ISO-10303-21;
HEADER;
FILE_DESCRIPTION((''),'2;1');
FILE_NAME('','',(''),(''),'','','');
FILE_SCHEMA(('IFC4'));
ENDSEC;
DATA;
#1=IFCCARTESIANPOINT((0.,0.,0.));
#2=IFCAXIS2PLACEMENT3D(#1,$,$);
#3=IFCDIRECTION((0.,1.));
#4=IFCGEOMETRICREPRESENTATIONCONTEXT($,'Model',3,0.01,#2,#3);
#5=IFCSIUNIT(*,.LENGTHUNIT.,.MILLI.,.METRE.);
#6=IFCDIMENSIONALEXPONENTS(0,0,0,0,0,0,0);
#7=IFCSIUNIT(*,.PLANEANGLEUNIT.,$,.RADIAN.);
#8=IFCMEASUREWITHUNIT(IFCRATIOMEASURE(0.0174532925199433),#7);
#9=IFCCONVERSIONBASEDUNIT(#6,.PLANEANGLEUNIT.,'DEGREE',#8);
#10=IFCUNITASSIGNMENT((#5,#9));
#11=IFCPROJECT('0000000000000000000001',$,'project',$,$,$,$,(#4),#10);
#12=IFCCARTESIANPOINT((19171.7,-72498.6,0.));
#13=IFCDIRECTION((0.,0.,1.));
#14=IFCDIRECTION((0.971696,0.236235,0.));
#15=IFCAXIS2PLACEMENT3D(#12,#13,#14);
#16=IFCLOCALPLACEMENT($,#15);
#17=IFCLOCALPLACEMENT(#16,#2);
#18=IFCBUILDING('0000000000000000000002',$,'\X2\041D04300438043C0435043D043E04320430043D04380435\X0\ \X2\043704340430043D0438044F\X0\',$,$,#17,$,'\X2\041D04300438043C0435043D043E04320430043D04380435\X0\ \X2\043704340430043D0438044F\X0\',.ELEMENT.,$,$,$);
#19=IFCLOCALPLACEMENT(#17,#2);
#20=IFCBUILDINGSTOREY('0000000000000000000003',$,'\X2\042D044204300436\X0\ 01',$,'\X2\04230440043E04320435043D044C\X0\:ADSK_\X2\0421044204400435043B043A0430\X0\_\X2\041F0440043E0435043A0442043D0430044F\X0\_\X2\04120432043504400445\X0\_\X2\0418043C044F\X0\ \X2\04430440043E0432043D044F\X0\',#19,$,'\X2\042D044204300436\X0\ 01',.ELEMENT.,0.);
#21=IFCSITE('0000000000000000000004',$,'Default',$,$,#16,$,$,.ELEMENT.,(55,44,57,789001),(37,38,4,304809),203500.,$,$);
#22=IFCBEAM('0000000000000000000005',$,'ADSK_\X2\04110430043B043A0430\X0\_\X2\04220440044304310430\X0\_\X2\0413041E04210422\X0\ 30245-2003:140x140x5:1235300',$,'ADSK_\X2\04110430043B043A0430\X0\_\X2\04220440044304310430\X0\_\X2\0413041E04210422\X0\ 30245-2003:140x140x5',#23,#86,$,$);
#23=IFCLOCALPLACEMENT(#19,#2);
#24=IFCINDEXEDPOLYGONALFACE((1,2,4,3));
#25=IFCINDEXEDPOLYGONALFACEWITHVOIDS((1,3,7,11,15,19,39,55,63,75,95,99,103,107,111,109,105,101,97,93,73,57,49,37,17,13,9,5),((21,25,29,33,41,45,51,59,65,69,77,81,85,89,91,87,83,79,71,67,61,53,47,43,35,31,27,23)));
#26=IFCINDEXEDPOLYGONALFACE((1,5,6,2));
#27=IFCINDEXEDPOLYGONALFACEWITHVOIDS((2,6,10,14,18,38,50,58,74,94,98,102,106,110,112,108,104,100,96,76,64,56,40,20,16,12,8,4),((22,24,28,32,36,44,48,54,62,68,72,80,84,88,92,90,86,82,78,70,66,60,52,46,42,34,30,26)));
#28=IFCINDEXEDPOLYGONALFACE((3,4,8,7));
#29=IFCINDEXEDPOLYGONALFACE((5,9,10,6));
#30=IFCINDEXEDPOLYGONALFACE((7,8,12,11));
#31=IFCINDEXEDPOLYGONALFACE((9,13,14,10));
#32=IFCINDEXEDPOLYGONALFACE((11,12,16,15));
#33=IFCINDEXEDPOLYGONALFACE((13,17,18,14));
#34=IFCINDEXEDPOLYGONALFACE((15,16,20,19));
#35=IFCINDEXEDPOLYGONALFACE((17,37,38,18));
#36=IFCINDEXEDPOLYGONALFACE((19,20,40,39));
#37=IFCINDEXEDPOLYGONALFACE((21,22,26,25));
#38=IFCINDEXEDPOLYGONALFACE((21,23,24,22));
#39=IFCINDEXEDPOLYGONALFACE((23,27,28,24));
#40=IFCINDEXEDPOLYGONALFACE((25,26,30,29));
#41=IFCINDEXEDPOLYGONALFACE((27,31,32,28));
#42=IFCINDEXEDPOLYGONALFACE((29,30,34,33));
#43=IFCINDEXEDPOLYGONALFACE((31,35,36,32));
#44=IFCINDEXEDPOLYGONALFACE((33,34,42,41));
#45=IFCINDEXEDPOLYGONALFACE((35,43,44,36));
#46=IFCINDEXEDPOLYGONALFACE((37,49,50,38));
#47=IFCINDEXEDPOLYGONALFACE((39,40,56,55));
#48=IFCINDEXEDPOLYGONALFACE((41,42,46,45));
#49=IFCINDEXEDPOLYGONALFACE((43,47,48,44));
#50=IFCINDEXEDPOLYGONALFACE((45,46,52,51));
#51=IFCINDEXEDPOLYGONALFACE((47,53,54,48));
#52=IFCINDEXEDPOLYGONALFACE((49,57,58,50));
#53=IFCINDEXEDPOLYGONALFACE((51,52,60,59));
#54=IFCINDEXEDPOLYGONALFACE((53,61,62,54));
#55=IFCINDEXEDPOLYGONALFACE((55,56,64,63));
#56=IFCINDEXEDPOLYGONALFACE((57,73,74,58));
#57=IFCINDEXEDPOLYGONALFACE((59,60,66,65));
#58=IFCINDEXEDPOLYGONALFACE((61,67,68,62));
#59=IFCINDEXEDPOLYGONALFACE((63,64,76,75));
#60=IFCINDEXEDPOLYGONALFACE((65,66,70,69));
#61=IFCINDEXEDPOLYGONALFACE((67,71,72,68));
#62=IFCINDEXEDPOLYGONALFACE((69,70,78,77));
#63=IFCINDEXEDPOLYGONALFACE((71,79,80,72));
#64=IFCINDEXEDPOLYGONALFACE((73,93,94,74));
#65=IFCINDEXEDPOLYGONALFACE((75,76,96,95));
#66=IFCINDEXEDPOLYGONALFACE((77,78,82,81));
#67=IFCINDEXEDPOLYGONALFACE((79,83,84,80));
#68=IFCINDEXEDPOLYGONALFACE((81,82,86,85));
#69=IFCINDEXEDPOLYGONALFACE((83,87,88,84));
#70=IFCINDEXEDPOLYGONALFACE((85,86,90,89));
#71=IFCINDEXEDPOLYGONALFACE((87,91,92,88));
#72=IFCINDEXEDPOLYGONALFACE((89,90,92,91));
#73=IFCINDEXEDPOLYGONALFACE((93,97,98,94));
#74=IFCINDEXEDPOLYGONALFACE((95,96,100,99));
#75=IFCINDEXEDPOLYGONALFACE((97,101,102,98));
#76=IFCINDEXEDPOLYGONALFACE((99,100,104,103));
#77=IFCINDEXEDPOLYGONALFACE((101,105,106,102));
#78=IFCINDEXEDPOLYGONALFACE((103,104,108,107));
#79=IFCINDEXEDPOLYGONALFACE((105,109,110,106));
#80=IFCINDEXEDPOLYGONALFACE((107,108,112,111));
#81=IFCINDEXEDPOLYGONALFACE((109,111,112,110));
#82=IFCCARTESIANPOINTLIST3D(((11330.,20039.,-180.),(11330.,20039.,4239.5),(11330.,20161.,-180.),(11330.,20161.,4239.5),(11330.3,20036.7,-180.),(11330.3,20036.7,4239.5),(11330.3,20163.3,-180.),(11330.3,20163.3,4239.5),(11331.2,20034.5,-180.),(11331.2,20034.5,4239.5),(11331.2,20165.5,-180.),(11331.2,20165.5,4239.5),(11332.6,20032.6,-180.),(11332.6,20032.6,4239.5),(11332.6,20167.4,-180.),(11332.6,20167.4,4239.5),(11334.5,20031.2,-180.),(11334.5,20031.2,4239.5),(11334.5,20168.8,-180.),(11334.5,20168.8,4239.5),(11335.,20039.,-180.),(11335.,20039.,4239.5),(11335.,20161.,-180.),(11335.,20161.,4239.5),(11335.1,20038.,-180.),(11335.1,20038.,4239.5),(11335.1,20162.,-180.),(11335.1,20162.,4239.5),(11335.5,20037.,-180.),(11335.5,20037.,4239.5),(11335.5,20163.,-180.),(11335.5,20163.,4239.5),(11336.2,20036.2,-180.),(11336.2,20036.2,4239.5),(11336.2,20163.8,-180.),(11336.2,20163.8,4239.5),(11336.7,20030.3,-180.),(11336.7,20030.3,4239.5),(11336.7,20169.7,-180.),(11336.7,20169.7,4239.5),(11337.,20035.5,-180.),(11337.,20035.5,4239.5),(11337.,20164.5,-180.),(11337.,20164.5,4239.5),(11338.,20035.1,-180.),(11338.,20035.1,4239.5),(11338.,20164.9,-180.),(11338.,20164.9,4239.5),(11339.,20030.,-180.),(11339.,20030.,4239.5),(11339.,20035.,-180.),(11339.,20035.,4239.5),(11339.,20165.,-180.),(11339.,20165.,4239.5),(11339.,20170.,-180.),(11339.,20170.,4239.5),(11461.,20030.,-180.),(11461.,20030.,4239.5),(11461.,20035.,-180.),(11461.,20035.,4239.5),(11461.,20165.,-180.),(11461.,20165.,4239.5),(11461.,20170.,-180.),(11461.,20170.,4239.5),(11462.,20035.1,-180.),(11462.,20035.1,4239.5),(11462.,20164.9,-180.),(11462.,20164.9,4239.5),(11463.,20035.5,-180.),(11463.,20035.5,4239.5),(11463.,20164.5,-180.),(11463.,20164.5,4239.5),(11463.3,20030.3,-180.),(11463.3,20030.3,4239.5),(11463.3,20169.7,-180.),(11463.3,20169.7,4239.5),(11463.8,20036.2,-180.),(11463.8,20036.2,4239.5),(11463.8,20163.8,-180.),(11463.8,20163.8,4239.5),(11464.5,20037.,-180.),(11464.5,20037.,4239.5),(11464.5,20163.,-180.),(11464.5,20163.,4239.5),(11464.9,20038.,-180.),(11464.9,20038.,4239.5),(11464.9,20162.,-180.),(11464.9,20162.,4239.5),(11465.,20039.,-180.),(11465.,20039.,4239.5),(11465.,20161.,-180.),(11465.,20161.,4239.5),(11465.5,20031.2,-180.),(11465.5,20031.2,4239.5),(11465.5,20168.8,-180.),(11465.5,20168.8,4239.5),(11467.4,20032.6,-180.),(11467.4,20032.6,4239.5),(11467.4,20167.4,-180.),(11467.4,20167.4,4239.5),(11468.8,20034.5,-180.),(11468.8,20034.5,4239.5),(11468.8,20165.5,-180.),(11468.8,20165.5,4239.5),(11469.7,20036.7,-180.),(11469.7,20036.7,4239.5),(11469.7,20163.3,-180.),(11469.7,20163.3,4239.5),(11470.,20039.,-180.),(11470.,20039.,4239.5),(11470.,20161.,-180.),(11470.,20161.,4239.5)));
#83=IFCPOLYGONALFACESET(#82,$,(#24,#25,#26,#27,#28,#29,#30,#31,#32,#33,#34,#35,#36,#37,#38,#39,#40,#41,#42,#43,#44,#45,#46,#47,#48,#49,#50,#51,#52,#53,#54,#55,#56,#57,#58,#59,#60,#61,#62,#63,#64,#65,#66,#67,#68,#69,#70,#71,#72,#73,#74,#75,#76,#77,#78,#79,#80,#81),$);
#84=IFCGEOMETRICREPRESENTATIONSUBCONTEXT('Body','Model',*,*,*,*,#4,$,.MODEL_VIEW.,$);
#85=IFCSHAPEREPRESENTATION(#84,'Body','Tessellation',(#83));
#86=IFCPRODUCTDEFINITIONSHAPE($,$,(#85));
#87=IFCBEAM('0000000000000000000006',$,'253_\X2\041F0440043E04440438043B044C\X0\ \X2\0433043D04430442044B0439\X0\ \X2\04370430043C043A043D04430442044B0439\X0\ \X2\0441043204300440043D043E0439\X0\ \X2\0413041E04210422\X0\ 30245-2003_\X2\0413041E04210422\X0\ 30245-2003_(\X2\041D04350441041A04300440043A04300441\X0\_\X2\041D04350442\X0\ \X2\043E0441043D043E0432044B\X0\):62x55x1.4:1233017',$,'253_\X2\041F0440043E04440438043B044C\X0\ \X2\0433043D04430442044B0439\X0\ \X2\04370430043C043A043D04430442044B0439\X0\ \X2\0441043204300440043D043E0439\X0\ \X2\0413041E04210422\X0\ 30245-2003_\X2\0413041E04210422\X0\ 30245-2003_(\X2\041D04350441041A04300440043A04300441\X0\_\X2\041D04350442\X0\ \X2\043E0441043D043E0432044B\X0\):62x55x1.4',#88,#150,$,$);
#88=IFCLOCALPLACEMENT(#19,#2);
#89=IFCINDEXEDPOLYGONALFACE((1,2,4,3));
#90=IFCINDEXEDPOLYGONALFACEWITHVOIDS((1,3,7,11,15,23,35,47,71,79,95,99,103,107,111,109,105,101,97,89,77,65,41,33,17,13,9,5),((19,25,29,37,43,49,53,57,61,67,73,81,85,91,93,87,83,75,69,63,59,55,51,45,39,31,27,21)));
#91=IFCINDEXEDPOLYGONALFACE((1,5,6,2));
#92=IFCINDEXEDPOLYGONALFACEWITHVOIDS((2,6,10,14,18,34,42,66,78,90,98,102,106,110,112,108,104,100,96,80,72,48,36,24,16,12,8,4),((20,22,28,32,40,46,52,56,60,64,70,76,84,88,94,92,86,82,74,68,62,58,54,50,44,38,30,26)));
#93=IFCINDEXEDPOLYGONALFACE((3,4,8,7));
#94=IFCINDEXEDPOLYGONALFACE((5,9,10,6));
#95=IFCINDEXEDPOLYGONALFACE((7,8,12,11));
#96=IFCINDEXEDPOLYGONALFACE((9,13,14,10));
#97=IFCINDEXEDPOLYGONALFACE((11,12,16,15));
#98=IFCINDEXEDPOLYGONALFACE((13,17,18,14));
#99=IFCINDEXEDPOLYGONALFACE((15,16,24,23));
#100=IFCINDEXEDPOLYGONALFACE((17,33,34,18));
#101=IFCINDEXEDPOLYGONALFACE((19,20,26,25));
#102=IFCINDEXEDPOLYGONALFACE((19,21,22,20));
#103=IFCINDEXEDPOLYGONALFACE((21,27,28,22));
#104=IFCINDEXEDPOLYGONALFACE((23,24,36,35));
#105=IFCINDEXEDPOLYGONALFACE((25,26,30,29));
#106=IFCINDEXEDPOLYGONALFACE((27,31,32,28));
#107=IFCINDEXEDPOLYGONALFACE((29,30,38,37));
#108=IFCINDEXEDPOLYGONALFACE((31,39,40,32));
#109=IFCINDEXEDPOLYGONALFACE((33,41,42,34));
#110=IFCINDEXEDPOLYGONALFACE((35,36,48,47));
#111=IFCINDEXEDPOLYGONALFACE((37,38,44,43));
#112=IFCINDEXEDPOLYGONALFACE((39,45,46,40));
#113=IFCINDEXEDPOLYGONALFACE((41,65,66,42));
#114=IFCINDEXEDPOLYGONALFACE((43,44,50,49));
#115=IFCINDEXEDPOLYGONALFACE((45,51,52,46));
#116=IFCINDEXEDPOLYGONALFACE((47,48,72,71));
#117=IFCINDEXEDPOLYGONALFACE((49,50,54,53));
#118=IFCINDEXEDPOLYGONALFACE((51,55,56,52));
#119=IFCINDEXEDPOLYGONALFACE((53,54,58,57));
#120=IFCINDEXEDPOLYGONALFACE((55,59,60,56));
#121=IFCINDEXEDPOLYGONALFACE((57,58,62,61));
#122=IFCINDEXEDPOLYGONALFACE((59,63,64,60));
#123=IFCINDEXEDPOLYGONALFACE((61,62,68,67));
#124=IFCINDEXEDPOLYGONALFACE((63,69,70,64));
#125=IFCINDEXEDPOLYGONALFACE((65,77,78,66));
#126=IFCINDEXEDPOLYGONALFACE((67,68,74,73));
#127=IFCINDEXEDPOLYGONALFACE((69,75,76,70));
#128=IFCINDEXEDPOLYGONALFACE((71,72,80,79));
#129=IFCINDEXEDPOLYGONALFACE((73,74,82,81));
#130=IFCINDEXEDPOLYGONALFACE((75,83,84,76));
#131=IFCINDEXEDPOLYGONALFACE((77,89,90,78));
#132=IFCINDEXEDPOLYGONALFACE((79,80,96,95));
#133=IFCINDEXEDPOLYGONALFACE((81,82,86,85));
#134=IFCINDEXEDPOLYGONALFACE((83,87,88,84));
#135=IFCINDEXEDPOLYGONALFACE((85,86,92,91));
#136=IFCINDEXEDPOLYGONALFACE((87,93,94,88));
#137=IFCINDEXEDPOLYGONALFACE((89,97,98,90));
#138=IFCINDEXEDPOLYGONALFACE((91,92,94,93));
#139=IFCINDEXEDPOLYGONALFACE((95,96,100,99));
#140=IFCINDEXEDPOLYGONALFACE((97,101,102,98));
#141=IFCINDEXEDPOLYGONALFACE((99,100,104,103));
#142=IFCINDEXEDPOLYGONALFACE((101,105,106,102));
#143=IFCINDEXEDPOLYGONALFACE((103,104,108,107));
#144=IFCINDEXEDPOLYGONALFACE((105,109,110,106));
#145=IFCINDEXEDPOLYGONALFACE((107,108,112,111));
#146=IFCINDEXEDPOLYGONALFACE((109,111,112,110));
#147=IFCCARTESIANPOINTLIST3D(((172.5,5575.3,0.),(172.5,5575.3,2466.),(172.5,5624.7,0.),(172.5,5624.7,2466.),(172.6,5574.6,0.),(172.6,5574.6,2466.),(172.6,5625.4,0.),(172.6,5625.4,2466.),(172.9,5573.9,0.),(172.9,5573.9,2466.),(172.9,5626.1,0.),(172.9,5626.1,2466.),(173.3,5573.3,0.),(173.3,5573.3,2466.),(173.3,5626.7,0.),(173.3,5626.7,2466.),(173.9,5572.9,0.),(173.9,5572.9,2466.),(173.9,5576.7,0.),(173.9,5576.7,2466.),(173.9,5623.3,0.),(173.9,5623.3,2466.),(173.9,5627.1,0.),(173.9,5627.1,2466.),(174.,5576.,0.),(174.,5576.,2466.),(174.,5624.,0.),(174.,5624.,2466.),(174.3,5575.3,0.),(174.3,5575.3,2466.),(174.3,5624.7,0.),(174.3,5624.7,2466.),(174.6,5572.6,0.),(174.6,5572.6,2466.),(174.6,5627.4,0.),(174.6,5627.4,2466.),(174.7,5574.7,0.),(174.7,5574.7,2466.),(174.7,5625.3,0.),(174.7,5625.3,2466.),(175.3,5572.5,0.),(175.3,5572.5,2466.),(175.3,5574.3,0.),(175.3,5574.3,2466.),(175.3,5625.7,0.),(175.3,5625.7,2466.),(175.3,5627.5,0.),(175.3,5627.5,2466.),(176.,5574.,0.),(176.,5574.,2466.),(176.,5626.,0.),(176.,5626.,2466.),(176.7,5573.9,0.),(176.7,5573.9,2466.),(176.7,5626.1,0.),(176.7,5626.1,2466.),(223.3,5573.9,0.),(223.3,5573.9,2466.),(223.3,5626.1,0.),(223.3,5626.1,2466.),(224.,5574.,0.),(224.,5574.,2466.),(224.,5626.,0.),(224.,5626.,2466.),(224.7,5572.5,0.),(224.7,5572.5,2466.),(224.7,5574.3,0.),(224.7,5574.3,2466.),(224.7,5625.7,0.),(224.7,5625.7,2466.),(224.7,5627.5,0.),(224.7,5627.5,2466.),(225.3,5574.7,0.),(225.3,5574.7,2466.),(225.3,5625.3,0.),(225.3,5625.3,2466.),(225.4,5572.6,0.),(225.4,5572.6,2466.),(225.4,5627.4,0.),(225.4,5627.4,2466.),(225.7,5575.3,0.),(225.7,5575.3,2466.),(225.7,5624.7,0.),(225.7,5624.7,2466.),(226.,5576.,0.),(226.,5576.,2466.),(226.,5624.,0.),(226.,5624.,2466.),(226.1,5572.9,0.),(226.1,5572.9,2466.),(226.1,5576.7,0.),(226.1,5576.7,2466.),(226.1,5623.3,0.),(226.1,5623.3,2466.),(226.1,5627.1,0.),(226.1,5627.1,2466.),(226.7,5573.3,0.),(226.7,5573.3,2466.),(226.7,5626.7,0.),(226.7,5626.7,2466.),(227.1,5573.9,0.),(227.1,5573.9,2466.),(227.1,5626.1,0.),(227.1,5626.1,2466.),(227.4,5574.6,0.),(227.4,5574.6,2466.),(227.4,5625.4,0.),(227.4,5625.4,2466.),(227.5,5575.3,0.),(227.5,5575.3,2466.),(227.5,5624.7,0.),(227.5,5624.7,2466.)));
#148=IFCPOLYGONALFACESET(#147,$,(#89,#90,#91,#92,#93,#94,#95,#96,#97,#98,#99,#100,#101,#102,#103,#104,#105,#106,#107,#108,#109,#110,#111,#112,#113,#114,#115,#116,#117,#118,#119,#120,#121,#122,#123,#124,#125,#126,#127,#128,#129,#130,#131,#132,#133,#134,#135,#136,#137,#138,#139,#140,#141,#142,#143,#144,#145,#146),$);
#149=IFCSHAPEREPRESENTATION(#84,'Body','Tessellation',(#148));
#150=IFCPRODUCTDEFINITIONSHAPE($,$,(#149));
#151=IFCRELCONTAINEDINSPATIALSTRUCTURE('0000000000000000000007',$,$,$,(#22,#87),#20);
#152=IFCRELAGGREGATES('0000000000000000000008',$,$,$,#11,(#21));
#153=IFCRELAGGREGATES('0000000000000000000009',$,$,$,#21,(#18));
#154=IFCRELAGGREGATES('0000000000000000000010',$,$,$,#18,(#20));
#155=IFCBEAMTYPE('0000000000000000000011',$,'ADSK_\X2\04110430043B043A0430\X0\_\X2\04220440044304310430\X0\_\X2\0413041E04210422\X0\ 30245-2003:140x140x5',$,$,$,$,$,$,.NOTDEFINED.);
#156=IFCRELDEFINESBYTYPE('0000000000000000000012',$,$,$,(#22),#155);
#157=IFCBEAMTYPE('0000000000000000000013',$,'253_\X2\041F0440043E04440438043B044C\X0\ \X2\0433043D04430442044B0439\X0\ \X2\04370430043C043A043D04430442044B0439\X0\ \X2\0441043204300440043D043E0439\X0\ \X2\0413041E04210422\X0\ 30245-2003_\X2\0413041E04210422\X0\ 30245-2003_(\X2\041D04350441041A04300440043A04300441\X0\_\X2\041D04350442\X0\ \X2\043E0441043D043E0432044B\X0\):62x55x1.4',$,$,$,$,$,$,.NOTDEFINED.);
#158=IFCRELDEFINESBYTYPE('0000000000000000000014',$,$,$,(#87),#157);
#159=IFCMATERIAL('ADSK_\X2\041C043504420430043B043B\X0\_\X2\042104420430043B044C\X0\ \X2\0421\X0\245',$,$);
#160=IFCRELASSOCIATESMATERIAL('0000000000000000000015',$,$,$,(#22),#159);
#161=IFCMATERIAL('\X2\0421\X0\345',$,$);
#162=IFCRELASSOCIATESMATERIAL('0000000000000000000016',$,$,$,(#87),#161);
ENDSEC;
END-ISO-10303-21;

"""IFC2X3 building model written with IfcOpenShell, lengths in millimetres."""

from ifc_helpers import new_model, entity, si_unit, converted_unit, direction, frame, frame_2d, origin, place, context, subcontext, project, spatial, polyline, circle_curve, parameter, trimmed, segment, composite_curve, outline, extrude, material, type_object, element, save


model = new_model("IFC2X3")

# Units and contexts
model_context = context("Model", 3, precision=0.01, world=origin(), true_north=direction((0.0, 1.0)))
body_context = subcontext(model_context, "Body", "Model", "MODEL_VIEW")
ifc_project = project(units=[si_unit("LENGTHUNIT", "METRE", prefix="MILLI"), converted_unit("PLANEANGLEUNIT", "DEGREE", entity("IfcRatioMeasure", 0.0174532925199433), si_unit("PLANEANGLEUNIT", "RADIAN"), dimensions=[0, 0, 0, 0, 0, 0, 0])], contexts=[model_context])

# Site, building, storey
site_placement = place(None, frame((19171.7, -72498.6, 0.0), z_axis=(0.0, 0.0, 1.0), x_axis=(0.971696, 0.236235, 0.0)))
site = spatial("IfcSite", under=ifc_project, at=site_placement, Name="Default", CompositionType="ELEMENT", RefLatitude=(55, 44, 57, 789001), RefLongitude=(37, 38, 4, 304809), RefElevation=203500.0)
building_placement = place(site_placement, origin())
building = spatial("IfcBuilding", under=site, at=building_placement, Name="Наименование здания", LongName="Наименование здания", CompositionType="ELEMENT")
storey_placement = place(building_placement, origin())
storey = spatial("IfcBuildingStorey", under=building, at=storey_placement, Name="Этаж 01", ObjectType="Уровень:ADSK_Стрелка_Проектная_Вверх_Имя уровня", LongName="Этаж 01", CompositionType="ELEMENT", Elevation=0.0)

# Beams
ifc_material_1 = material(Name="ADSK_Металл_Сталь С245")
beam_type_1 = type_object("IfcBeamType", Name="ADSK_Балка_Труба_ГОСТ 30245-2003:140x140x5", PredefinedType="NOTDEFINED")
beam_1_placement = place(storey_placement, frame((11328.4, 20028.4, -180.0), z_axis=(1.0, 0.0, 0.0), x_axis=(0.0, 0.0, -1.0)))
element("IfcBeam", 1, at=beam_1_placement, inside=storey, type_object=beam_type_1, material=ifc_material_1, Name="ADSK_Балка_Труба_ГОСТ 30245-2003:140x140x5:1235300", ObjectType="ADSK_Балка_Труба_ГОСТ 30245-2003:140x140x5", context=body_context, shape_type="SweptSolid", body=[
    extrude(outline(composite_curve([segment(trimmed(circle_curve(frame_2d((61.0, -61.0), x_axis=(1.0, 0.0)), 9.0), [parameter(270.0)], [parameter(0.0)], True, "PARAMETER"), True, "CONTINUOUS"), segment(polyline([(70.0, -61.0), (70.0, 61.0)]), True, "CONTINUOUS"), segment(trimmed(circle_curve(frame_2d((61.0, 61.0), x_axis=(1.0, 0.0)), 9.0), [parameter(0.0)], [parameter(90.0)], True, "PARAMETER"), True, "CONTINUOUS"), segment(polyline([(61.0, 70.0), (-61.0, 70.0)]), True, "CONTINUOUS"), segment(trimmed(circle_curve(frame_2d((-61.0, 61.0), x_axis=(1.0, 0.0)), 9.0), [parameter(90.0)], [parameter(180.0)], True, "PARAMETER"), True, "CONTINUOUS"), segment(polyline([(-70.0, 61.0), (-70.0, -61.0)]), True, "CONTINUOUS"), segment(trimmed(circle_curve(frame_2d((-61.0, -61.0), x_axis=(1.0, 0.0)), 9.0), [parameter(180.0)], [parameter(270.0)], True, "PARAMETER"), True, "CONTINUOUS"), segment(polyline([(-61.0, -70.0), (61.0, -70.0)]), True, "CONTINUOUS")], self_intersect=False), holes=[composite_curve([segment(polyline([(61.0, -65.0), (-61.0, -65.0)]), True, "CONTINUOUS"), segment(trimmed(circle_curve(frame_2d((-61.0, -61.0), x_axis=(1.0, 0.0)), 4.0), [parameter(180.0)], [parameter(270.0)], True, "PARAMETER"), False, "CONTINUOUS"), segment(polyline([(-65.0, -61.0), (-65.0, 61.0)]), True, "CONTINUOUS"), segment(trimmed(circle_curve(frame_2d((-61.0, 61.0), x_axis=(1.0, 0.0)), 4.0), [parameter(90.0)], [parameter(180.0)], True, "PARAMETER"), False, "CONTINUOUS"), segment(polyline([(-61.0, 65.0), (61.0, 65.0)]), True, "CONTINUOUS"), segment(trimmed(circle_curve(frame_2d((61.0, 61.0), x_axis=(1.0, 0.0)), 4.0), [parameter(0.0)], [parameter(90.0)], True, "PARAMETER"), False, "CONTINUOUS"), segment(polyline([(65.0, 61.0), (65.0, -61.0)]), True, "CONTINUOUS"), segment(trimmed(circle_curve(frame_2d((61.0, -61.0), x_axis=(1.0, 0.0)), 4.0), [parameter(270.0)], [parameter(0.0)], True, "PARAMETER"), False, "CONTINUOUS")], self_intersect=False)]), frame((-4419.5, 71.6, 71.6), z_axis=(1.0, 0.0, 0.0), x_axis=(0.0, 0.0, 1.0)), (0.0, 0.0, 1.0), 4419.5),
])
ifc_material_2 = material(Name="С345")
beam_type_2 = type_object("IfcBeamType", Name="253_Профиль гнутый замкнутый сварной ГОСТ 30245-2003_ГОСТ 30245-2003_(НесКаркас_Нет основы):62x55x1.4", PredefinedType="NOTDEFINED")
beam_2_placement = place(storey_placement, frame((170.9, 5570.9, 0.0), z_axis=(1.0, 0.0, 0.0), x_axis=(0.0, 0.0, -1.0)))
element("IfcBeam", 2, at=beam_2_placement, inside=storey, type_object=beam_type_2, material=ifc_material_2, Name="253_Профиль гнутый замкнутый сварной ГОСТ 30245-2003_ГОСТ 30245-2003_(НесКаркас_Нет основы):62x55x1.4:1233017", ObjectType="253_Профиль гнутый замкнутый сварной ГОСТ 30245-2003_ГОСТ 30245-2003_(НесКаркас_Нет основы):62x55x1.4", context=body_context, shape_type="SweptSolid", body=[
    extrude(outline(composite_curve([segment(trimmed(circle_curve(frame_2d((24.7, -24.7), x_axis=(1.0, 0.0)), 2.8), [parameter(270.0)], [parameter(0.0)], True, "PARAMETER"), True, "CONTINUOUS"), segment(polyline([(27.5, -24.7), (27.5, 24.7)]), True, "CONTINUOUS"), segment(trimmed(circle_curve(frame_2d((24.7, 24.7), x_axis=(1.0, 0.0)), 2.8), [parameter(0.0)], [parameter(90.0)], True, "PARAMETER"), True, "CONTINUOUS"), segment(polyline([(24.7, 27.5), (-24.7, 27.5)]), True, "CONTINUOUS"), segment(trimmed(circle_curve(frame_2d((-24.7, 24.7), x_axis=(1.0, 0.0)), 2.8), [parameter(90.0)], [parameter(180.0)], True, "PARAMETER"), True, "CONTINUOUS"), segment(polyline([(-27.5, 24.7), (-27.5, -24.7)]), True, "CONTINUOUS"), segment(trimmed(circle_curve(frame_2d((-24.7, -24.7), x_axis=(1.0, 0.0)), 2.8), [parameter(180.0)], [parameter(270.0)], True, "PARAMETER"), True, "CONTINUOUS"), segment(polyline([(-24.7, -27.5), (24.7, -27.5)]), True, "CONTINUOUS")], self_intersect=False), holes=[composite_curve([segment(polyline([(23.3, -26.1), (-23.3, -26.1)]), True, "CONTINUOUS"), segment(trimmed(circle_curve(frame_2d((-23.3, -23.3), x_axis=(1.0, 0.0)), 2.8), [parameter(180.0)], [parameter(270.0)], True, "PARAMETER"), False, "CONTINUOUS"), segment(polyline([(-26.1, -23.3), (-26.1, 23.3)]), True, "CONTINUOUS"), segment(trimmed(circle_curve(frame_2d((-23.3, 23.3), x_axis=(1.0, 0.0)), 2.8), [parameter(90.0)], [parameter(180.0)], True, "PARAMETER"), False, "CONTINUOUS"), segment(polyline([(-23.3, 26.1), (23.3, 26.1)]), True, "CONTINUOUS"), segment(trimmed(circle_curve(frame_2d((23.3, 23.3), x_axis=(1.0, 0.0)), 2.8), [parameter(0.0)], [parameter(90.0)], True, "PARAMETER"), False, "CONTINUOUS"), segment(polyline([(26.1, 23.3), (26.1, -23.3)]), True, "CONTINUOUS"), segment(trimmed(circle_curve(frame_2d((23.3, -23.3), x_axis=(1.0, 0.0)), 2.8), [parameter(270.0)], [parameter(0.0)], True, "PARAMETER"), False, "CONTINUOUS")], self_intersect=False)]), frame((-2466.0, 29.1, 29.1), z_axis=(1.0, 0.0, 0.0), x_axis=(0.0, 1.0, 0.0)), (0.0, 0.0, 1.0), 2466.0),
])

save(model, "model.ifc")
